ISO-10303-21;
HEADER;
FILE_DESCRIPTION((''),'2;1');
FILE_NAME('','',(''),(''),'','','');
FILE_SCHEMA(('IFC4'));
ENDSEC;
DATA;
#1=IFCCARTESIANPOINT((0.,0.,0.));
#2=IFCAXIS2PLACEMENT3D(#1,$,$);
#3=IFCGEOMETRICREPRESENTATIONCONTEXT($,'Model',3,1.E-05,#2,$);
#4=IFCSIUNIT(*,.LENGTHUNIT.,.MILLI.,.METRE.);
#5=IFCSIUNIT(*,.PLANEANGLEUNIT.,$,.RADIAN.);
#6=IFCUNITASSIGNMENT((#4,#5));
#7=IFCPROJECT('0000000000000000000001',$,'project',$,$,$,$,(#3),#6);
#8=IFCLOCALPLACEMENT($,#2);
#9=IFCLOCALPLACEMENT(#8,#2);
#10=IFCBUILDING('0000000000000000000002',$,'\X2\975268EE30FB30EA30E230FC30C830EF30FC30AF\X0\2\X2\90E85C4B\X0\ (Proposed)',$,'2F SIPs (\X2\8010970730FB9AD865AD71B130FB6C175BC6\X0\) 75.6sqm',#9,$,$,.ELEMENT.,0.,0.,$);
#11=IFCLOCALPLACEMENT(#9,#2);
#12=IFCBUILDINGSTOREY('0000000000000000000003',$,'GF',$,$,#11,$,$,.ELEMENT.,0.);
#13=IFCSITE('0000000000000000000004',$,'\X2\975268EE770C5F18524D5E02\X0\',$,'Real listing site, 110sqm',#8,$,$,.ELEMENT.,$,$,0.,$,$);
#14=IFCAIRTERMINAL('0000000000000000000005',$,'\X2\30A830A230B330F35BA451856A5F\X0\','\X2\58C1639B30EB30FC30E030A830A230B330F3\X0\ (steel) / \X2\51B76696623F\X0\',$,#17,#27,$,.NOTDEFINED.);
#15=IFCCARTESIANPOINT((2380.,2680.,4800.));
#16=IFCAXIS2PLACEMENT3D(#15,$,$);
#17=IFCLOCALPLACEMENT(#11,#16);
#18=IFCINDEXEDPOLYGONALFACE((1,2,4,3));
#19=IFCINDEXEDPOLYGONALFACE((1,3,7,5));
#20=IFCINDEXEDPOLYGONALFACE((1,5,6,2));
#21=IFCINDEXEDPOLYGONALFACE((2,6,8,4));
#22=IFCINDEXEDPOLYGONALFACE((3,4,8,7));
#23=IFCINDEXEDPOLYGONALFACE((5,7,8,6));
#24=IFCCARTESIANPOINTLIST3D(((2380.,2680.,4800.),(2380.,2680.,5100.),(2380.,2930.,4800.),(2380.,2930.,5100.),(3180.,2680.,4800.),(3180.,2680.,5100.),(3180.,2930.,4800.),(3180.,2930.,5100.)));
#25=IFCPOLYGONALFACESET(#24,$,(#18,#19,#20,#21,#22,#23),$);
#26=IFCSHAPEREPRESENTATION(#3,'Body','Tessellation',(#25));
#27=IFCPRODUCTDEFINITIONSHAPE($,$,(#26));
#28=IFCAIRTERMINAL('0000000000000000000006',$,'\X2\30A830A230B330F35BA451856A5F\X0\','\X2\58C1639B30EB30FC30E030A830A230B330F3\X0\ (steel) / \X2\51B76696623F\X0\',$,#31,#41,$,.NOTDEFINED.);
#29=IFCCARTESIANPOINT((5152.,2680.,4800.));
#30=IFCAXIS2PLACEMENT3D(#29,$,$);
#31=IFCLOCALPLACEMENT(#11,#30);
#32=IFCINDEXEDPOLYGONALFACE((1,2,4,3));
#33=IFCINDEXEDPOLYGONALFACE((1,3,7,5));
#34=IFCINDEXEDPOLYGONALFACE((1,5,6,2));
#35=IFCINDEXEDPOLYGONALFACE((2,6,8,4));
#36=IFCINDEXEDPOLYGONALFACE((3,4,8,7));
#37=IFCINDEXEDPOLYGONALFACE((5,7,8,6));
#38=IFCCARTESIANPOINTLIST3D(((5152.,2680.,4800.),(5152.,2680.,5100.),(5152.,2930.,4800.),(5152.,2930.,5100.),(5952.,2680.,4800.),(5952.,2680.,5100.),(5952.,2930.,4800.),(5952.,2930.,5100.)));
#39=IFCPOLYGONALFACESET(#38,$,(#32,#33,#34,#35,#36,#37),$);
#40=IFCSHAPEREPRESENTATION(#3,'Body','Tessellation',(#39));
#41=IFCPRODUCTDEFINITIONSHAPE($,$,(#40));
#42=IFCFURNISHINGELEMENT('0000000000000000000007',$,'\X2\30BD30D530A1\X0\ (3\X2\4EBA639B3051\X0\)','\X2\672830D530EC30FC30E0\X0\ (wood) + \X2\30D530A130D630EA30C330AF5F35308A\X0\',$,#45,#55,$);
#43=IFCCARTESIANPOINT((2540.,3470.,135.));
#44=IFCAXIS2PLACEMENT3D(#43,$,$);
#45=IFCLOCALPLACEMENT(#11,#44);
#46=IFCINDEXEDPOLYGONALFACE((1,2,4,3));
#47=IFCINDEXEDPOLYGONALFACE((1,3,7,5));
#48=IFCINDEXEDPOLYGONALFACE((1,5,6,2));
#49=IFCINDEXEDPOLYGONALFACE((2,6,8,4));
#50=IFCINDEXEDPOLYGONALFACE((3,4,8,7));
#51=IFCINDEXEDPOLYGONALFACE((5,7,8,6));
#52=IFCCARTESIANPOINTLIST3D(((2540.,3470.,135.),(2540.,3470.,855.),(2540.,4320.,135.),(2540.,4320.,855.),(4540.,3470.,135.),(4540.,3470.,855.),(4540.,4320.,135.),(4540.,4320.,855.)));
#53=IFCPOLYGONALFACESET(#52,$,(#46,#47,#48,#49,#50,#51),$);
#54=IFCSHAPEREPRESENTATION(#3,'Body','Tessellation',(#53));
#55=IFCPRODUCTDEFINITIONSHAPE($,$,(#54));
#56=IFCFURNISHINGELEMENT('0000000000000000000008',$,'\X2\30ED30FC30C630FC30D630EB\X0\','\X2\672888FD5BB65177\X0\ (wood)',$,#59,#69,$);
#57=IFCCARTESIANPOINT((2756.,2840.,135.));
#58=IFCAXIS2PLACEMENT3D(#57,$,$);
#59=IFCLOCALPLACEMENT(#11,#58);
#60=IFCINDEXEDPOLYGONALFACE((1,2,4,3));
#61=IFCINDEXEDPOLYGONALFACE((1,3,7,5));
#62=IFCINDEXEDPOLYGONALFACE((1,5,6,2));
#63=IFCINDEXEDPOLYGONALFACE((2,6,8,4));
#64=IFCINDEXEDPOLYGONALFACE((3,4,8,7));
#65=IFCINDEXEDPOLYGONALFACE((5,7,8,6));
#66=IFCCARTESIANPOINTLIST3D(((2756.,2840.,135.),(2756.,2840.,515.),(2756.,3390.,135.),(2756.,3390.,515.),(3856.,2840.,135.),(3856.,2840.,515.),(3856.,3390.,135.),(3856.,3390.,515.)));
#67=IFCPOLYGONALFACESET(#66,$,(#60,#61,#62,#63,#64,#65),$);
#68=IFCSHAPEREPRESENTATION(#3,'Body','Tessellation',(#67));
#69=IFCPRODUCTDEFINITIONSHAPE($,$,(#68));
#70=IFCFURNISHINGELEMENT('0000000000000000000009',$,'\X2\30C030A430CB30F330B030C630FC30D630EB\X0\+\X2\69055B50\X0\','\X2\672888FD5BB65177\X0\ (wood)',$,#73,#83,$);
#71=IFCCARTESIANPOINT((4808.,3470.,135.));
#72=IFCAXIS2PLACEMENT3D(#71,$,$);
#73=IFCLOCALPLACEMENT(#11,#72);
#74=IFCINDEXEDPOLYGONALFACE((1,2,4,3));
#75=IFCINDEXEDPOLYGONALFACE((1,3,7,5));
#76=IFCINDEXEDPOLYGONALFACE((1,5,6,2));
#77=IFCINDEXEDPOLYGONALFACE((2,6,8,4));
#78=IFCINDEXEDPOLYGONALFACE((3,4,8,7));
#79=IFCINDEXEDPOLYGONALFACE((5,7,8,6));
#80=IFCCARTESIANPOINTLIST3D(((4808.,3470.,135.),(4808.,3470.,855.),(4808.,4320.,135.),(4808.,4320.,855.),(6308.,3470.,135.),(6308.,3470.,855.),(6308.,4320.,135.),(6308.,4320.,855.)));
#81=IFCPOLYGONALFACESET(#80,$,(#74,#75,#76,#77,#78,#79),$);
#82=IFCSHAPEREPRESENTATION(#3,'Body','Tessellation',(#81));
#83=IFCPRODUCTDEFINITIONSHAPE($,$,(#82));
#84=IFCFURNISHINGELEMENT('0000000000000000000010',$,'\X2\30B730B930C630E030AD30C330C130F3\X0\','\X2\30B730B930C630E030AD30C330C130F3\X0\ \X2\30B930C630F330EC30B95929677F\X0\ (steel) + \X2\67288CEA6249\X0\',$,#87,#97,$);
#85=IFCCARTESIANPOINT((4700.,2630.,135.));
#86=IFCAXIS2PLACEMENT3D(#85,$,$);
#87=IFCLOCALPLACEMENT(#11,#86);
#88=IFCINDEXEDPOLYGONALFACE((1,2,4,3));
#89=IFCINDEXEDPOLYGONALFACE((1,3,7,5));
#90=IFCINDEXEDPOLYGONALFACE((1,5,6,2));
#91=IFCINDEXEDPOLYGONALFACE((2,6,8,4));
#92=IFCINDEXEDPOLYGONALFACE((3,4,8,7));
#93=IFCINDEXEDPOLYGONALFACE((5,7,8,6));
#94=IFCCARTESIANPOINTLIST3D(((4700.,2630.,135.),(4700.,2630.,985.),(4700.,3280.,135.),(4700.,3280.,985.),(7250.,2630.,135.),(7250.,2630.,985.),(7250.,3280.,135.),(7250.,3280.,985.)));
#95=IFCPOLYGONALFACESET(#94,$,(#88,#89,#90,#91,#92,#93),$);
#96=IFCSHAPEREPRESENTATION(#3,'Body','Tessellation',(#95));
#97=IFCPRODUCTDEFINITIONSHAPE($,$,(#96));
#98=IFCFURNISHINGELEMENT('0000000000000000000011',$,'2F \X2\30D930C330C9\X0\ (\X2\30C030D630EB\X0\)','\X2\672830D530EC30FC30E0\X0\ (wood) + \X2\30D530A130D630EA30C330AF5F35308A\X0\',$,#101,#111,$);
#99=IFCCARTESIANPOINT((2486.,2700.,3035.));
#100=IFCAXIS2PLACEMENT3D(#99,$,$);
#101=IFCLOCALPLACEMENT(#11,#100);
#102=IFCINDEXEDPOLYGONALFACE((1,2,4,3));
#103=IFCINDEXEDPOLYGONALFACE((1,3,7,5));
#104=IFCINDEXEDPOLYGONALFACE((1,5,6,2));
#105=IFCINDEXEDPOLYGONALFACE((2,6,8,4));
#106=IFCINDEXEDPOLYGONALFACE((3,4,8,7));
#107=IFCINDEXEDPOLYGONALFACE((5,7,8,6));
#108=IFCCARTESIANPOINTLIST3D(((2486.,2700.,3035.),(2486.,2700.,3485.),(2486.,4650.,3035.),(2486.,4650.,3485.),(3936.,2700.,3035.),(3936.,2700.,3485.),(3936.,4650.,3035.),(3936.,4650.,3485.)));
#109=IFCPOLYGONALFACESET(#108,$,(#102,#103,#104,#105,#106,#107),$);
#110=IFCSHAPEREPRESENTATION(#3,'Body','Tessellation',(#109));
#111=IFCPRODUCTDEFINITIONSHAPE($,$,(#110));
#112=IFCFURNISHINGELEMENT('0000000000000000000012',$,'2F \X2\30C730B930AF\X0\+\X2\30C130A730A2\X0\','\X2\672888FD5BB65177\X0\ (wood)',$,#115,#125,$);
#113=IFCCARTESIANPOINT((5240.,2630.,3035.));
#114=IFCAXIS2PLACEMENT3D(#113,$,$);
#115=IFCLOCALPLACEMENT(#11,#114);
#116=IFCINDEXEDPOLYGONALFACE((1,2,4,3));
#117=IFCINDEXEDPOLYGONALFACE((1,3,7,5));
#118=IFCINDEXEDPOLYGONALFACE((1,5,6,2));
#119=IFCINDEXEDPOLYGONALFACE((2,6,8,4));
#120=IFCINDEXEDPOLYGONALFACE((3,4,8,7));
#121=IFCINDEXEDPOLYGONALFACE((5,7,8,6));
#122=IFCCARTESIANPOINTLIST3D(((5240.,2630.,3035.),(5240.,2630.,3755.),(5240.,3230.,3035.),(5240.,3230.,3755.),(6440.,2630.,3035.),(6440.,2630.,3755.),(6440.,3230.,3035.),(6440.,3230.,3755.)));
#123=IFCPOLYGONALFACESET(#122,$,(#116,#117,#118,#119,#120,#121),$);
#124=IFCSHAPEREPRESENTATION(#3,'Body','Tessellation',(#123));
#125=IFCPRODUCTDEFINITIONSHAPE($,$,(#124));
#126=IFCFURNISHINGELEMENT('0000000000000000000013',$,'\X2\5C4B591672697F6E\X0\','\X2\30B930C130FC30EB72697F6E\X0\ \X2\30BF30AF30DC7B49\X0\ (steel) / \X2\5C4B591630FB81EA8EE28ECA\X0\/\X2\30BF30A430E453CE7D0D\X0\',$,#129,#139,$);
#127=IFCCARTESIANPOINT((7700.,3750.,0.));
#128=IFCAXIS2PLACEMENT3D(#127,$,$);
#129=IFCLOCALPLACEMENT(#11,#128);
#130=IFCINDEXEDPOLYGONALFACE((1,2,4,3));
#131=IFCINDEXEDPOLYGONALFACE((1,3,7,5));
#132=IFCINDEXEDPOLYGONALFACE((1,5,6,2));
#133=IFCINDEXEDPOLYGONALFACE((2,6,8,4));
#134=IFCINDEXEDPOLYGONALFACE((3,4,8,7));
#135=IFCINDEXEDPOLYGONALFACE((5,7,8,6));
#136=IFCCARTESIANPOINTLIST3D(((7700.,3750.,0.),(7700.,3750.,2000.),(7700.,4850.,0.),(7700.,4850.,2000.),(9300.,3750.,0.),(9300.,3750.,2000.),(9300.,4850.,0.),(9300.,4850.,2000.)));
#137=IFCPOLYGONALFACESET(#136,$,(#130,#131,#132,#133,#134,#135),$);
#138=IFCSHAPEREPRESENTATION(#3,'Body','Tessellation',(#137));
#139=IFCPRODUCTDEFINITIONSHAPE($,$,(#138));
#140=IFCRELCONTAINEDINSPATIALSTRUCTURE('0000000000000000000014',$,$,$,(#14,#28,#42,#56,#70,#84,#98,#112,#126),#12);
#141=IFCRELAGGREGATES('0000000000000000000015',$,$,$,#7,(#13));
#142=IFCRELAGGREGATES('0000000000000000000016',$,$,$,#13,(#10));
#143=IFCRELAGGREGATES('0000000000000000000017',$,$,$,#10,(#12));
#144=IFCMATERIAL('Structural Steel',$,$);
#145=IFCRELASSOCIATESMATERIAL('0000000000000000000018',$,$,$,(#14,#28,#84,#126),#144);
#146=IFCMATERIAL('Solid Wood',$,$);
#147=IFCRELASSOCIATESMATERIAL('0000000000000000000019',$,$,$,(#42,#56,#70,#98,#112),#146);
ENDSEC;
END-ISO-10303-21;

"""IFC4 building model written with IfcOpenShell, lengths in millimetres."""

from ifc_helpers import new_model, si_unit, frame, frame_2d, origin, place, context, project, spatial, rectangle, extrude, material, element, save


model = new_model("IFC4")

# Units and contexts
model_context = context("Model", 3, precision=1e-05, world=origin())
ifc_project = project(units=[si_unit("LENGTHUNIT", "METRE", prefix="MILLI"), si_unit("PLANEANGLEUNIT", "RADIAN")], contexts=[model_context])

# Site, building, storey
site_placement = place(None, origin())
site = spatial("IfcSite", under=ifc_project, at=site_placement, Name="青森県弘前市", ObjectType="Real listing site, 110sqm", CompositionType="ELEMENT", RefElevation=0.0)
building_placement = place(site_placement, origin())
building = spatial("IfcBuilding", under=site, at=building_placement, Name="青森・リモートワーク2部屋 (Proposed)", ObjectType="2F SIPs (耐震・高断熱・気密) 75.6sqm", CompositionType="ELEMENT", ElevationOfRefHeight=0.0, ElevationOfTerrain=0.0)
storey_placement = place(building_placement, origin())
storey = spatial("IfcBuildingStorey", under=building, at=storey_placement, Name="GF", CompositionType="ELEMENT", Elevation=0.0)

# Shared definitions
ifc_material_1 = material(Name="Solid Wood")

# Shared definitions
ifc_material_2 = material(Name="Structural Steel")

# Air terminals
air_terminal_1_placement = place(storey_placement, frame((2380.0, 2680.0, 4800.0)))
element("IfcAirTerminal", 1, at=air_terminal_1_placement, inside=storey, material=ifc_material_2, Name="エアコン室内機", Description="壁掛ルームエアコン (steel) / 冷暖房", PredefinedType="NOTDEFINED", context=model_context, shape_type="SweptSolid", body=[
    extrude(rectangle(XDim=800.0, YDim=250.0, at=frame_2d((400.0, 125.0))), frame((2380.0, 2680.0, 4800.0)), (0.0, 0.0, 1.0), 300.0),
])
air_terminal_2_placement = place(storey_placement, frame((5152.0, 2680.0, 4800.0)))
element("IfcAirTerminal", 2, at=air_terminal_2_placement, inside=storey, material=ifc_material_2, Name="エアコン室内機", Description="壁掛ルームエアコン (steel) / 冷暖房", PredefinedType="NOTDEFINED", context=model_context, shape_type="SweptSolid", body=[
    extrude(rectangle(XDim=800.0, YDim=250.0, at=frame_2d((400.0, 125.0))), frame((5152.0, 2680.0, 4800.0)), (0.0, 0.0, 1.0), 300.0),
])

# Furnishing elements
furnishing_1_placement = place(storey_placement, frame((2540.0, 3470.0, 135.0)))
element("IfcFurnishingElement", 3, at=furnishing_1_placement, inside=storey, material=ifc_material_1, Name="ソファ (3人掛け)", Description="木フレーム (wood) + ファブリック張り", context=model_context, shape_type="SweptSolid", body=[
    extrude(rectangle(XDim=2000.0, YDim=850.0, at=frame_2d((1000.0, 425.0))), frame((2540.0, 3470.0, 135.0)), (0.0, 0.0, 1.0), 720.0),
])
furnishing_2_placement = place(storey_placement, frame((2756.0, 2840.0, 135.0)))
element("IfcFurnishingElement", 4, at=furnishing_2_placement, inside=storey, material=ifc_material_1, Name="ローテーブル", Description="木製家具 (wood)", context=model_context, shape_type="SweptSolid", body=[
    extrude(rectangle(XDim=1100.0, YDim=550.0, at=frame_2d((550.0, 275.0))), frame((2756.0, 2840.0, 135.0)), (0.0, 0.0, 1.0), 380.0),
])
furnishing_3_placement = place(storey_placement, frame((4808.0, 3470.0, 135.0)))
element("IfcFurnishingElement", 5, at=furnishing_3_placement, inside=storey, material=ifc_material_1, Name="ダイニングテーブル+椅子", Description="木製家具 (wood)", context=model_context, shape_type="SweptSolid", body=[
    extrude(rectangle(XDim=1500.0, YDim=850.0, at=frame_2d((750.0, 425.0))), frame((4808.0, 3470.0, 135.0)), (0.0, 0.0, 1.0), 720.0),
])
furnishing_4_placement = place(storey_placement, frame((4700.0, 2630.0, 135.0)))
element("IfcFurnishingElement", 6, at=furnishing_4_placement, inside=storey, material=ifc_material_2, Name="システムキッチン", Description="システムキッチン ステンレス天板 (steel) + 木質扉", context=model_context, shape_type="SweptSolid", body=[
    extrude(rectangle(XDim=2550.0, YDim=650.0, at=frame_2d((1275.0, 325.0))), frame((4700.0, 2630.0, 135.0)), (0.0, 0.0, 1.0), 850.0),
])
furnishing_5_placement = place(storey_placement, frame((2486.0, 2700.0, 3035.0)))
element("IfcFurnishingElement", 7, at=furnishing_5_placement, inside=storey, material=ifc_material_1, Name="2F ベッド (ダブル)", Description="木フレーム (wood) + ファブリック張り", context=model_context, shape_type="SweptSolid", body=[
    extrude(rectangle(XDim=1450.0, YDim=1950.0, at=frame_2d((725.0, 975.0))), frame((2486.0, 2700.0, 3035.0)), (0.0, 0.0, 1.0), 450.0),
])
furnishing_6_placement = place(storey_placement, frame((5240.0, 2630.0, 3035.0)))
element("IfcFurnishingElement", 8, at=furnishing_6_placement, inside=storey, material=ifc_material_1, Name="2F デスク+チェア", Description="木製家具 (wood)", context=model_context, shape_type="SweptSolid", body=[
    extrude(rectangle(XDim=1200.0, YDim=600.0, at=frame_2d((600.0, 300.0))), frame((5240.0, 2630.0, 3035.0)), (0.0, 0.0, 1.0), 720.0),
])
furnishing_7_placement = place(storey_placement, frame((7700.0, 3750.0, 0.0)))
element("IfcFurnishingElement", 9, at=furnishing_7_placement, inside=storey, material=ifc_material_2, Name="屋外物置", Description="スチール物置 タクボ等 (steel) / 屋外・自転車/タイヤ収納", context=model_context, shape_type="SweptSolid", body=[
    extrude(rectangle(XDim=1600.0, YDim=1100.0, at=frame_2d((800.0, 550.0))), frame((7700.0, 3750.0, 0.0)), (0.0, 0.0, 1.0), 2000.0),
])

save(model, "model.ifc")
